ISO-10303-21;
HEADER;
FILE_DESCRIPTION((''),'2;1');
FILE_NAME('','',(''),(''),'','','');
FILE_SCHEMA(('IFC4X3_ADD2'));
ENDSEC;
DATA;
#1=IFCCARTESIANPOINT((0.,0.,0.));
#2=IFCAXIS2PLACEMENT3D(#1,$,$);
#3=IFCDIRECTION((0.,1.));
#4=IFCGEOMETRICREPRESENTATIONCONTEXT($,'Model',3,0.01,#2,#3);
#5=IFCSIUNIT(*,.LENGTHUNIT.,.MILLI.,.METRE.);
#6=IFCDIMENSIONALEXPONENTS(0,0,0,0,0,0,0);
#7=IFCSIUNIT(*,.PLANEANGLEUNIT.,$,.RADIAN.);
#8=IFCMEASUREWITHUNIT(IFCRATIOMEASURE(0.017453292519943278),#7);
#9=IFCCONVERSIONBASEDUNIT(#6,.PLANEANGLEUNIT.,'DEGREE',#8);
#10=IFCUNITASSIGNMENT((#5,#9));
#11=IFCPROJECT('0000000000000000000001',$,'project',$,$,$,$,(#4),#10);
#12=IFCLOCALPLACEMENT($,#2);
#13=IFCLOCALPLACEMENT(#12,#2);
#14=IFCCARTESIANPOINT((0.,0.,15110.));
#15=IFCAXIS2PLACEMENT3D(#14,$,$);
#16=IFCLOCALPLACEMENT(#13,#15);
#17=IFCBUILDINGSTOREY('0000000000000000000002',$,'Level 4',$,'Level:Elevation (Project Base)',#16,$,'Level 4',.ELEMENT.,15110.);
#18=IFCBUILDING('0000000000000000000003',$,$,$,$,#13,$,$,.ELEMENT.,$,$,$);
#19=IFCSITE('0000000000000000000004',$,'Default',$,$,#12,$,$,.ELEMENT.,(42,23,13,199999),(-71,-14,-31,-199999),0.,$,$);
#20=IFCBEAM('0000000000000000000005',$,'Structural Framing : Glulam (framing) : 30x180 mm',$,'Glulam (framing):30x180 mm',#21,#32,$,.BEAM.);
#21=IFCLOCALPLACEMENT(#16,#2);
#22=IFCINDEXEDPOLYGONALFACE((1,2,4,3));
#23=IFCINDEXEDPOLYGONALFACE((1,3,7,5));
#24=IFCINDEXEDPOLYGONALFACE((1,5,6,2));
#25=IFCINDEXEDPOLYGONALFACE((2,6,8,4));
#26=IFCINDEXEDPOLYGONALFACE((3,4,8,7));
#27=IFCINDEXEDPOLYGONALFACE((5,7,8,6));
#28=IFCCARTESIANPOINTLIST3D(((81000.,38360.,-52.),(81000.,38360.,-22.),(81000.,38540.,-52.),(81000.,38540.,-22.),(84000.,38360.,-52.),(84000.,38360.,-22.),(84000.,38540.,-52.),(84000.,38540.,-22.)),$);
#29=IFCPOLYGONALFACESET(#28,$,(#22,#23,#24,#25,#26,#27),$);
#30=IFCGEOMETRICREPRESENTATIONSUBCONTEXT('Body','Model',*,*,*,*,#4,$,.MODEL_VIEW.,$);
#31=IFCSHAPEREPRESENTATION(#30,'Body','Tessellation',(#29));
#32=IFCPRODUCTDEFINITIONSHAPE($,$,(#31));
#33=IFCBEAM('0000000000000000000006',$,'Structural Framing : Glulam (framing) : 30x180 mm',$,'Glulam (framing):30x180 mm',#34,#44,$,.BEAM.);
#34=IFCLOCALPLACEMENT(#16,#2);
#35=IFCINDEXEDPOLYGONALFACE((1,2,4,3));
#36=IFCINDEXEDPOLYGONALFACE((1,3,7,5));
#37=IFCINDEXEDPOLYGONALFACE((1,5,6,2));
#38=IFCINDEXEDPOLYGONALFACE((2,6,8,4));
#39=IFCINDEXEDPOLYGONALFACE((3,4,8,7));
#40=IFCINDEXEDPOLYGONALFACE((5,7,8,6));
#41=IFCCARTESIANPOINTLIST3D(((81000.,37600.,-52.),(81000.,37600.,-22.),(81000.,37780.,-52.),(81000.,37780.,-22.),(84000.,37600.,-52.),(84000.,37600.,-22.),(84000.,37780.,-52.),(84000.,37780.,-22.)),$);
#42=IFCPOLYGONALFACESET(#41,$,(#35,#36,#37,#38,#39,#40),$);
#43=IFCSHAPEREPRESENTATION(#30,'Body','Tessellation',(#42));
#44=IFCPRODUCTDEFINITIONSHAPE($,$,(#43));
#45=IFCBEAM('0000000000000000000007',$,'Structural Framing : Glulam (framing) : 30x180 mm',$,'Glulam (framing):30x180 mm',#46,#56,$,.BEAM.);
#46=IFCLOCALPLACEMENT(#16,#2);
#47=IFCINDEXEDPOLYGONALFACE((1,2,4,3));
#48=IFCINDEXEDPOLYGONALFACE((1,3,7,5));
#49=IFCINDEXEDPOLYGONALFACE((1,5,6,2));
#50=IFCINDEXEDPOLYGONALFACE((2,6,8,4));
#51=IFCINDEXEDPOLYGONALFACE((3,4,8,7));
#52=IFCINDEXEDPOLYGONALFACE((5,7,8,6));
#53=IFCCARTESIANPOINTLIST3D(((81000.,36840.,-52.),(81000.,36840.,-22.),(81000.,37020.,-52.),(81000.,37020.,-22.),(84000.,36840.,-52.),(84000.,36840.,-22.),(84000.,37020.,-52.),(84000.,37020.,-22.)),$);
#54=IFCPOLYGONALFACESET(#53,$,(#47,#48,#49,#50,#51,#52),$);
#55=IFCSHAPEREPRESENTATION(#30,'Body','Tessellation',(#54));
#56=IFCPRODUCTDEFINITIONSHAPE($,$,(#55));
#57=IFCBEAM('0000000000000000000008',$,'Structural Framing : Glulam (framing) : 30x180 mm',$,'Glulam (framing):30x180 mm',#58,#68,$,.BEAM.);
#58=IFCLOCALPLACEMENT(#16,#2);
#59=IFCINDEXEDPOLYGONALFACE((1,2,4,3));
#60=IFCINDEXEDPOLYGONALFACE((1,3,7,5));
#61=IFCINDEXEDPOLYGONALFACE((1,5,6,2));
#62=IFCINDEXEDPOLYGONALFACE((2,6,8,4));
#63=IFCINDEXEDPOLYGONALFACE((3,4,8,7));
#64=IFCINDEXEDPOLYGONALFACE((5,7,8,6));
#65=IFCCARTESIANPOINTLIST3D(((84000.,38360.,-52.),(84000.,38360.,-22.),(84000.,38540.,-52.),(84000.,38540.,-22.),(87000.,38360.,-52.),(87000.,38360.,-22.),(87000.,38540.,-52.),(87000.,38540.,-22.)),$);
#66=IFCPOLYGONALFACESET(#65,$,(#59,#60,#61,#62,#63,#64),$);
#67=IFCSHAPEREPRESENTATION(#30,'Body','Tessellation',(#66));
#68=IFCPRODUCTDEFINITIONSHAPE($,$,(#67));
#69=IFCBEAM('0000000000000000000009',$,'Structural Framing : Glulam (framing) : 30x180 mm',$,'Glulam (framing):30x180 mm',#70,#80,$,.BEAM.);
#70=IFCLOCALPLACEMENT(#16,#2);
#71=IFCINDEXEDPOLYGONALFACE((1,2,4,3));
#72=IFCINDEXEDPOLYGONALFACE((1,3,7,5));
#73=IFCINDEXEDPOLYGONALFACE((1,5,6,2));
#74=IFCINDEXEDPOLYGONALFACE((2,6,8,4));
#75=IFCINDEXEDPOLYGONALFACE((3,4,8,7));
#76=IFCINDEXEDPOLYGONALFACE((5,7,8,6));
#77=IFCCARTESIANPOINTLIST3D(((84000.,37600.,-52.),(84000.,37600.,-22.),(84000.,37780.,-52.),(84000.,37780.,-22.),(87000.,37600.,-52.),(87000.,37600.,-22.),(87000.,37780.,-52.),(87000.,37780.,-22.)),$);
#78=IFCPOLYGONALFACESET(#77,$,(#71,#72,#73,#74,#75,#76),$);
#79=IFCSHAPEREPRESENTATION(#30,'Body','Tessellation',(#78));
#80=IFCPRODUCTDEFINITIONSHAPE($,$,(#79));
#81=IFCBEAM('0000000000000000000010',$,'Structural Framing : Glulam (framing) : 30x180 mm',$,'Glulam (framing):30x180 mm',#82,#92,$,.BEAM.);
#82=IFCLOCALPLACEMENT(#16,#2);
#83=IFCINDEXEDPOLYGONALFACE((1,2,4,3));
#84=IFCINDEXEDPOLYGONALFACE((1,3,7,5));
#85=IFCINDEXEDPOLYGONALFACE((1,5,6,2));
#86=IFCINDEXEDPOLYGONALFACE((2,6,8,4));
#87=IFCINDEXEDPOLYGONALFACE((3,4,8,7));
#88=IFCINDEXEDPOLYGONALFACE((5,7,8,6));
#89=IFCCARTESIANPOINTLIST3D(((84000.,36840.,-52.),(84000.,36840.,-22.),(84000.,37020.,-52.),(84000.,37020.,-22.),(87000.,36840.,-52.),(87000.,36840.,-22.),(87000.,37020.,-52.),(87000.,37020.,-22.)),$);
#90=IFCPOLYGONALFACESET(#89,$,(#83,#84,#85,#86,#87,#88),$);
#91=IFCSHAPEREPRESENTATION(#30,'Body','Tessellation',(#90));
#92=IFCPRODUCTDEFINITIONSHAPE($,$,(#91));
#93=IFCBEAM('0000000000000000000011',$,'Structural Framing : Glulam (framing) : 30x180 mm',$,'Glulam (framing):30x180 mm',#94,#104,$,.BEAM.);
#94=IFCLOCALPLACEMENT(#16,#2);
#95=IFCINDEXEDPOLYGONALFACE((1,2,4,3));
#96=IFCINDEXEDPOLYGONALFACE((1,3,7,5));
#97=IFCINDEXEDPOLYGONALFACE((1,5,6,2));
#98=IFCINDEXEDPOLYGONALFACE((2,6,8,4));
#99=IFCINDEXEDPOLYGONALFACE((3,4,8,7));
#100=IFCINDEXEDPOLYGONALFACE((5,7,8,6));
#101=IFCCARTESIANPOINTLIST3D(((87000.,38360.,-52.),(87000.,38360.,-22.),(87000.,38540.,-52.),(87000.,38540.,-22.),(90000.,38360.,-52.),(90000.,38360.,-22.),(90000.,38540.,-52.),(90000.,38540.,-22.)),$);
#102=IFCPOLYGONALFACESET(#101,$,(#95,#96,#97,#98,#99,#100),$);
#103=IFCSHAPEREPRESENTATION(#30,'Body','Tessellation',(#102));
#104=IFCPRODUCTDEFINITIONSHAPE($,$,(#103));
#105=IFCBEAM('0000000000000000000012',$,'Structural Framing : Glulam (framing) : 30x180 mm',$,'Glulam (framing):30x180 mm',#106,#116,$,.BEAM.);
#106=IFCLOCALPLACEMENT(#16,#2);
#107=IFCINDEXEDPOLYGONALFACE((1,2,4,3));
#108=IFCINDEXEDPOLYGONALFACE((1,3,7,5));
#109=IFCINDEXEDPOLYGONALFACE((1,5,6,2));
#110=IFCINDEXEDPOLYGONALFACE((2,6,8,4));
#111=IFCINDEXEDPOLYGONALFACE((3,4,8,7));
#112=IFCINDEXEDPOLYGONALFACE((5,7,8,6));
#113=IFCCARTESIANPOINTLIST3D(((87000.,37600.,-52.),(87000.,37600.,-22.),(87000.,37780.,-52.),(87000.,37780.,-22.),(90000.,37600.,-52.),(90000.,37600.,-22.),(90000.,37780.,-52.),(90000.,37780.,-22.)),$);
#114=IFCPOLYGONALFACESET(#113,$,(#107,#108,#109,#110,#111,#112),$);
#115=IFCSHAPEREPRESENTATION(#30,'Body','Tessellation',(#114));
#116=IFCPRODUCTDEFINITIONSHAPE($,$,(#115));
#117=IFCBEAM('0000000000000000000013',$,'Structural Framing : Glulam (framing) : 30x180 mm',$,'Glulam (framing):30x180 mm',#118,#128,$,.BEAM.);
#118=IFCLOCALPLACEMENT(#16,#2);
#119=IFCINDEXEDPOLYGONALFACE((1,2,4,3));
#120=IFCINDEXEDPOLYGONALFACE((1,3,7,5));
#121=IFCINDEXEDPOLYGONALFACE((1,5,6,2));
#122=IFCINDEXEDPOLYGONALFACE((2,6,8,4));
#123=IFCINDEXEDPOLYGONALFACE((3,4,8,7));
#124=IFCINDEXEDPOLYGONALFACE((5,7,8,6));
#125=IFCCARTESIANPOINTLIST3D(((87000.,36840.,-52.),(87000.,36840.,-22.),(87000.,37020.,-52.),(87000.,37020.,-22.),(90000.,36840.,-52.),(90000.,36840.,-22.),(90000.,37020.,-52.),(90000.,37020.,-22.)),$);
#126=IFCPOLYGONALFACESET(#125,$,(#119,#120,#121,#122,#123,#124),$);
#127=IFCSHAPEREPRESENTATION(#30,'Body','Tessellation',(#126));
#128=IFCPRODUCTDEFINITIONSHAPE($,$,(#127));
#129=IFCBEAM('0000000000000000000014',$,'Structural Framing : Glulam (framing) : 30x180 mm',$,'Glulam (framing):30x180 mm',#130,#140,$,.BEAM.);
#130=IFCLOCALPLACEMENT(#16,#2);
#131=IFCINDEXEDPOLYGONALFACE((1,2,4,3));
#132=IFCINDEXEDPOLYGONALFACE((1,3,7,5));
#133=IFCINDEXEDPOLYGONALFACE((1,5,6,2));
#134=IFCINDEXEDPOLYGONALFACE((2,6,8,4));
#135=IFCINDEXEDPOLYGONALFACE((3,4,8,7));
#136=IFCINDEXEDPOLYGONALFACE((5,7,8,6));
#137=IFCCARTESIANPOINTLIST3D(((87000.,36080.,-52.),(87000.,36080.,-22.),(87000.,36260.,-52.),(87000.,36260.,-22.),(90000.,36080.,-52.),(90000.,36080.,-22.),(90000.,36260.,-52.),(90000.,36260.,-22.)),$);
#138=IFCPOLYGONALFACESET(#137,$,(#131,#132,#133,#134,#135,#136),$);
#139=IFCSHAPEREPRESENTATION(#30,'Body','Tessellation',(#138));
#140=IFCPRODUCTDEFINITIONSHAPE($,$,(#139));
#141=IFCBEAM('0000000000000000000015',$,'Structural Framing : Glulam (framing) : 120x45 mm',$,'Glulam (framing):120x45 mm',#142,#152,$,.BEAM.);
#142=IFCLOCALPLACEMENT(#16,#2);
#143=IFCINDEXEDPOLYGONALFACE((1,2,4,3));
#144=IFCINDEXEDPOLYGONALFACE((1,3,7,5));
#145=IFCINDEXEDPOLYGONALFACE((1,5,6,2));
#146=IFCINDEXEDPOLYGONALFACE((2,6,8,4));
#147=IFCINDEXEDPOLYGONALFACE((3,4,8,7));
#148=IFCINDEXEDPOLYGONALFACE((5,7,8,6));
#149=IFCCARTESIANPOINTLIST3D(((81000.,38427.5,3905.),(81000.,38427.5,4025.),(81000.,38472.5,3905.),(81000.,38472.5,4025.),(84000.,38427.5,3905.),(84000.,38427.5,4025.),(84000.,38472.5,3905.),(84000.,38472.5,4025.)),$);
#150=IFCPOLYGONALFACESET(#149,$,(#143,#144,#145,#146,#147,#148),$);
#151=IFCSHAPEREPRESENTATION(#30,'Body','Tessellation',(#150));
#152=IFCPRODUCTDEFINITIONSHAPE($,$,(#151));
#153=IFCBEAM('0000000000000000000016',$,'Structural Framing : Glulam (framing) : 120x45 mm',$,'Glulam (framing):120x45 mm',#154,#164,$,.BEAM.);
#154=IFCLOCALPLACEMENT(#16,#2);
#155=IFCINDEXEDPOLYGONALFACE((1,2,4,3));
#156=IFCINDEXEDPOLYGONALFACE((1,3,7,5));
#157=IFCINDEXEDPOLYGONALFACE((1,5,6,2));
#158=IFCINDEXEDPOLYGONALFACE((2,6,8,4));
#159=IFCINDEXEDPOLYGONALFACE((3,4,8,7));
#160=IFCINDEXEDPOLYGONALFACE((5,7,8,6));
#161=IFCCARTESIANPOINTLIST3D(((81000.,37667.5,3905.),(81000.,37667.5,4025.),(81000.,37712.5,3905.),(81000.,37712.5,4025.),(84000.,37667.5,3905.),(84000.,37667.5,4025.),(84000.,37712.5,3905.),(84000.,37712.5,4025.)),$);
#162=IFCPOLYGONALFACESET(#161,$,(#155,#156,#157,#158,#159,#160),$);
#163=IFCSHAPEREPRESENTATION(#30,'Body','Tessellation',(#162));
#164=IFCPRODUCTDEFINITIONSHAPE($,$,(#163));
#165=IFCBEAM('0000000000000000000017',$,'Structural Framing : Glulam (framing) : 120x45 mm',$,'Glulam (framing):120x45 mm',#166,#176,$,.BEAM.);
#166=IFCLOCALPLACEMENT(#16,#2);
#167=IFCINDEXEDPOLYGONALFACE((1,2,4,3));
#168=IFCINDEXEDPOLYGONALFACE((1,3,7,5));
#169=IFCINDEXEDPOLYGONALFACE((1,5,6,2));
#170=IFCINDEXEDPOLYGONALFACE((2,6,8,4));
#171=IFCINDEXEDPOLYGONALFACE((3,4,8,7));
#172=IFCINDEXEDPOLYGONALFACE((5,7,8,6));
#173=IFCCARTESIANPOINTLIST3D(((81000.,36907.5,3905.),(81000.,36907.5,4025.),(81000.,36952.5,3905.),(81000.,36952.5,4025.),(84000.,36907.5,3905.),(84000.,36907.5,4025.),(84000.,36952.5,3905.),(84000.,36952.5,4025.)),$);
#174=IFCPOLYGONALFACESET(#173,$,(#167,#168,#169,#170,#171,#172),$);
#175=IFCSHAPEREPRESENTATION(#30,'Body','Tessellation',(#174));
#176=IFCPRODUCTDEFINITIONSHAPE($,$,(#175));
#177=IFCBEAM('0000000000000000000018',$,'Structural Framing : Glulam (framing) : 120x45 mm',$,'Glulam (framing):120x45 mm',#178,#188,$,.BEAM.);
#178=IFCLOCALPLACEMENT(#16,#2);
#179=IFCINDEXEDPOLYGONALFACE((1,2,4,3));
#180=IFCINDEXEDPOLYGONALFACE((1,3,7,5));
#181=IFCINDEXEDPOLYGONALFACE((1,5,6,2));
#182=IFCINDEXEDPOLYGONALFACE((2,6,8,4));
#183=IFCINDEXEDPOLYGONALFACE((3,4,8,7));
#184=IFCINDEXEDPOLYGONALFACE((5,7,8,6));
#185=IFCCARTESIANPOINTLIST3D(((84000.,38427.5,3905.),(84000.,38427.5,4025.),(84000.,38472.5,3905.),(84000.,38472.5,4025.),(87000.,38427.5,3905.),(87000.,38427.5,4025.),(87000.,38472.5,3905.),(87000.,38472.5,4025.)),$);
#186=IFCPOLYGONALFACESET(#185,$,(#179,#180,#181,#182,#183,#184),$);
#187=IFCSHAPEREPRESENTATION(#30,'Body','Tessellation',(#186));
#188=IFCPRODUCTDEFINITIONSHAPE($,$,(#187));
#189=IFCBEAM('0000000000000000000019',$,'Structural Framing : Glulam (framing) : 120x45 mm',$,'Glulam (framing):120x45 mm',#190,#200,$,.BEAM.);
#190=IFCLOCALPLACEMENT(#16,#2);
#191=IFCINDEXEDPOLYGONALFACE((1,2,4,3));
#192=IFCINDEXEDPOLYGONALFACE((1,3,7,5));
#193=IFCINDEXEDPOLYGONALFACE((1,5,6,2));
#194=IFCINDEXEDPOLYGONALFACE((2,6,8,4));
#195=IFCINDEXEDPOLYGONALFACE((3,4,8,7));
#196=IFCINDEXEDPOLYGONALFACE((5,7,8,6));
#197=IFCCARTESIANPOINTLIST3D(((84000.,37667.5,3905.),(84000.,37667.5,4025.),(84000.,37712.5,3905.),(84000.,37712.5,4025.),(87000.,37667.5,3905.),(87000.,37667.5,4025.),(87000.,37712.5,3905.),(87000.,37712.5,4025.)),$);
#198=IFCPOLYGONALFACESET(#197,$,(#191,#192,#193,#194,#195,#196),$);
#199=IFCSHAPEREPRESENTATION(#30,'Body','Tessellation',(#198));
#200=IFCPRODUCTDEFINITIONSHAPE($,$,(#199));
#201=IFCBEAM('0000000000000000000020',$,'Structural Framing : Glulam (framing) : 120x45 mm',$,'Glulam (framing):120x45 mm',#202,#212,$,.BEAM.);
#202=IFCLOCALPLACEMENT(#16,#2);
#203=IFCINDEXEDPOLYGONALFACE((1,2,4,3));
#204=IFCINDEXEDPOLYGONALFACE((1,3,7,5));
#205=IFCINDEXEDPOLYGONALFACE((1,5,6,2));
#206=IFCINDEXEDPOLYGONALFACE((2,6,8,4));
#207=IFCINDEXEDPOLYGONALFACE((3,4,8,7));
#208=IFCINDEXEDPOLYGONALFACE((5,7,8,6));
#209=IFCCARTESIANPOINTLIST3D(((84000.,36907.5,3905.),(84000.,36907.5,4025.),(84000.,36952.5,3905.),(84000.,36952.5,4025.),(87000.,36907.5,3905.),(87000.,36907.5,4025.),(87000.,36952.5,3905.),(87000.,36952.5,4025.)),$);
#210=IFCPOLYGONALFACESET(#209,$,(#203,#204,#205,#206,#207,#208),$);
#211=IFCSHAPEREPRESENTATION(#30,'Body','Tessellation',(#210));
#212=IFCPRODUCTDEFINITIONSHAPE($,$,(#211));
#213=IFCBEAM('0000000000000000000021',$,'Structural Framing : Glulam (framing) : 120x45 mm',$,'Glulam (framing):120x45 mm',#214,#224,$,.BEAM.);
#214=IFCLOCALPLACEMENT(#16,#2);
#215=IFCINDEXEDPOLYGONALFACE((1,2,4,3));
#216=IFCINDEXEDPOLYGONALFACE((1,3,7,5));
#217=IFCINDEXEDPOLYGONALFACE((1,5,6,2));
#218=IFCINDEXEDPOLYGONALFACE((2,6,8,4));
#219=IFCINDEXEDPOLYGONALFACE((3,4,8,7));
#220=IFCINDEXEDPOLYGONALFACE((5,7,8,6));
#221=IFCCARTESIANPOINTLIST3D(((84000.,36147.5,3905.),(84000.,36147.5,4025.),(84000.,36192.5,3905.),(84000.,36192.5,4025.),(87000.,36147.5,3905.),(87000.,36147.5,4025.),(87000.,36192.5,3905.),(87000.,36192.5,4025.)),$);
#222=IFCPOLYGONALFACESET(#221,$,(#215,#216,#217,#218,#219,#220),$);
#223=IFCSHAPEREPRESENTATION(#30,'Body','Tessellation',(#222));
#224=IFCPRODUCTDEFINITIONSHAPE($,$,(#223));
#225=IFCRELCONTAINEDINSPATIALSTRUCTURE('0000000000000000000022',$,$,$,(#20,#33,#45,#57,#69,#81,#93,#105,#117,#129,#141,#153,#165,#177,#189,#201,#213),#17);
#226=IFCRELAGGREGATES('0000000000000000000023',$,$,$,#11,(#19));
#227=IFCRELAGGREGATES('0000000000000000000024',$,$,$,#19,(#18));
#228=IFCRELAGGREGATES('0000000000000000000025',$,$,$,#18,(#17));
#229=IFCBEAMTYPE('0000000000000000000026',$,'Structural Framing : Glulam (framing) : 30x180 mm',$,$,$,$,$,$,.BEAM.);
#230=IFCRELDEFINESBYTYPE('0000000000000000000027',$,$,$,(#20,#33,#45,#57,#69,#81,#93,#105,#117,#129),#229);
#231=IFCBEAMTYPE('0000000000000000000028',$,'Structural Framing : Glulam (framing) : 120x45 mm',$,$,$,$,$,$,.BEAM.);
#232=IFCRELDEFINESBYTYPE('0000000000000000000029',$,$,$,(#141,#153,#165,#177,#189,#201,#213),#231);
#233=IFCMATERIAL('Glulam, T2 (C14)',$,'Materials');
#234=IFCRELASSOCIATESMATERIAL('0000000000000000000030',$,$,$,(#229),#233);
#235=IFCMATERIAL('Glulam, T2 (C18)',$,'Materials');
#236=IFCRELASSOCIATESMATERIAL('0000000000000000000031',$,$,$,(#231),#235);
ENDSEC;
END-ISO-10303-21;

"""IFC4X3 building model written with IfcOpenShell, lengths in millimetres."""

from ifc_helpers import new_model, entity, si_unit, converted_unit, direction, frame, origin, origin_2d_with_axis, place, context, subcontext, project, spatial, rectangle, extrude, source, transform, mapped, material, material_profile, profile_set, type_object, type_shapes, element, save


model = new_model("IFC4X3")

# Units and contexts
model_context = context("Model", 3, precision=0.01, world=origin(), true_north=direction((0.0, 1.0)))
body_context = subcontext(model_context, "Body", "Model", "MODEL_VIEW")
ifc_project = project(units=[si_unit("LENGTHUNIT", "METRE", prefix="MILLI"), converted_unit("PLANEANGLEUNIT", "DEGREE", entity("IfcRatioMeasure", 0.017453292519943278), si_unit("PLANEANGLEUNIT", "RADIAN"), dimensions=[0, 0, 0, 0, 0, 0, 0])], contexts=[model_context])

# Site, building, storey
site_placement = place(None, origin())
site = spatial("IfcSite", under=ifc_project, at=site_placement, Name="Default", CompositionType="ELEMENT", RefLatitude=(42, 23, 13, 199999), RefLongitude=(-71, -14, -31, -199999), RefElevation=0.0)
building_placement = place(site_placement, origin())
building = spatial("IfcBuilding", under=site, at=building_placement, CompositionType="ELEMENT")
storey_placement = place(building_placement, frame((0.0, 0.0, 15110.0)))
storey = spatial("IfcBuildingStorey", under=building, at=storey_placement, Name="Level 4", ObjectType="Level:Elevation (Project Base)", LongName="Level 4", CompositionType="ELEMENT", Elevation=15110.0)

# Beams
ifc_material_1 = material(Name="Glulam, T2 (C14)", Category="Materials")
ifc_material_profile_1 = material_profile(ifc_material_1, rectangle(XDim=30.0, YDim=180.0, at=origin_2d_with_axis()), Name="30x180 mm")
ifc_profile_set_1 = profile_set([ifc_material_profile_1], Name="30x180 mm")
beam_type_1 = type_object("IfcBeamType", Name="Structural Framing : Glulam (framing) : 30x180 mm", PredefinedType="BEAM", material=ifc_profile_set_1)
shared_shape_1 = source(origin(), body_context, "Body", "SweptSolid", [
    extrude(rectangle(XDim=30.0, YDim=180.0, at=origin_2d_with_axis()), frame((500.0, 0.0, 0.0), z_axis=(1.0, 0.0, 0.0), x_axis=(0.0, 0.0, -1.0)), (0.0, 0.0, 1.0), 3000.0),
])
type_shapes(beam_type_1, [shared_shape_1])
for number, where, name in (
    (1, (80500.0, 38450.0, -37.0), "Structural Framing : Glulam (framing) : 30x180 mm"),
    (2, (80500.0, 37690.0, -37.0), "Structural Framing : Glulam (framing) : 30x180 mm"),
    (3, (80500.0, 36930.0, -37.0), "Structural Framing : Glulam (framing) : 30x180 mm"),
    (4, (83500.0, 38450.0, -37.0), "Structural Framing : Glulam (framing) : 30x180 mm"),
    (5, (83500.0, 37690.0, -37.0), "Structural Framing : Glulam (framing) : 30x180 mm"),
    (6, (83500.0, 36930.0, -37.0), "Structural Framing : Glulam (framing) : 30x180 mm"),
    (7, (86500.0, 38450.0, -37.0), "Structural Framing : Glulam (framing) : 30x180 mm"),
    (8, (86500.0, 37690.0, -37.0), "Structural Framing : Glulam (framing) : 30x180 mm"),
    (9, (86500.0, 36930.0, -37.0), "Structural Framing : Glulam (framing) : 30x180 mm"),
    (10, (86500.0, 36170.0, -37.0), "Structural Framing : Glulam (framing) : 30x180 mm"),
):
    element("IfcBeam", number, at=place(storey_placement, frame(where)), inside=storey, type_object=beam_type_1, Name=name, ObjectType="Glulam (framing):30x180 mm", PredefinedType="BEAM", context=body_context, shape_type="MappedRepresentation", body=[
        mapped(shared_shape_1, transform((0.0, 0.0, 0.0), scale=1.0)),
    ])
ifc_material_2 = material(Name="Glulam, T2 (C18)", Category="Materials")
ifc_material_profile_2 = material_profile(ifc_material_2, rectangle(XDim=120.0, YDim=45.0, at=origin_2d_with_axis()), Name="120x45 mm")
ifc_profile_set_2 = profile_set([ifc_material_profile_2], Name="120x45 mm")
beam_type_2 = type_object("IfcBeamType", Name="Structural Framing : Glulam (framing) : 120x45 mm", PredefinedType="BEAM", material=ifc_profile_set_2)
shared_shape_2 = source(origin(), body_context, "Body", "SweptSolid", [
    extrude(rectangle(XDim=120.0, YDim=45.0, at=origin_2d_with_axis()), frame((500.0, 0.0, 0.0), z_axis=(1.0, 0.0, 0.0), x_axis=(0.0, 0.0, -1.0)), (0.0, 0.0, 1.0), 3000.0),
])
type_shapes(beam_type_2, [shared_shape_2])
for number, where, name in (
    (11, (80500.0, 38450.0, 3965.0), "Structural Framing : Glulam (framing) : 120x45 mm"),
    (12, (80500.0, 37690.0, 3965.0), "Structural Framing : Glulam (framing) : 120x45 mm"),
    (13, (80500.0, 36930.0, 3965.0), "Structural Framing : Glulam (framing) : 120x45 mm"),
    (14, (83500.0, 38450.0, 3965.0), "Structural Framing : Glulam (framing) : 120x45 mm"),
    (15, (83500.0, 37690.0, 3965.0), "Structural Framing : Glulam (framing) : 120x45 mm"),
    (16, (83500.0, 36930.0, 3965.0), "Structural Framing : Glulam (framing) : 120x45 mm"),
    (17, (83500.0, 36170.0, 3965.0), "Structural Framing : Glulam (framing) : 120x45 mm"),
):
    element("IfcBeam", number, at=place(storey_placement, frame(where)), inside=storey, type_object=beam_type_2, Name=name, ObjectType="Glulam (framing):120x45 mm", PredefinedType="BEAM", context=body_context, shape_type="MappedRepresentation", body=[
        mapped(shared_shape_2, transform((0.0, 0.0, 0.0), scale=1.0)),
    ])

save(model, "model.ifc")
